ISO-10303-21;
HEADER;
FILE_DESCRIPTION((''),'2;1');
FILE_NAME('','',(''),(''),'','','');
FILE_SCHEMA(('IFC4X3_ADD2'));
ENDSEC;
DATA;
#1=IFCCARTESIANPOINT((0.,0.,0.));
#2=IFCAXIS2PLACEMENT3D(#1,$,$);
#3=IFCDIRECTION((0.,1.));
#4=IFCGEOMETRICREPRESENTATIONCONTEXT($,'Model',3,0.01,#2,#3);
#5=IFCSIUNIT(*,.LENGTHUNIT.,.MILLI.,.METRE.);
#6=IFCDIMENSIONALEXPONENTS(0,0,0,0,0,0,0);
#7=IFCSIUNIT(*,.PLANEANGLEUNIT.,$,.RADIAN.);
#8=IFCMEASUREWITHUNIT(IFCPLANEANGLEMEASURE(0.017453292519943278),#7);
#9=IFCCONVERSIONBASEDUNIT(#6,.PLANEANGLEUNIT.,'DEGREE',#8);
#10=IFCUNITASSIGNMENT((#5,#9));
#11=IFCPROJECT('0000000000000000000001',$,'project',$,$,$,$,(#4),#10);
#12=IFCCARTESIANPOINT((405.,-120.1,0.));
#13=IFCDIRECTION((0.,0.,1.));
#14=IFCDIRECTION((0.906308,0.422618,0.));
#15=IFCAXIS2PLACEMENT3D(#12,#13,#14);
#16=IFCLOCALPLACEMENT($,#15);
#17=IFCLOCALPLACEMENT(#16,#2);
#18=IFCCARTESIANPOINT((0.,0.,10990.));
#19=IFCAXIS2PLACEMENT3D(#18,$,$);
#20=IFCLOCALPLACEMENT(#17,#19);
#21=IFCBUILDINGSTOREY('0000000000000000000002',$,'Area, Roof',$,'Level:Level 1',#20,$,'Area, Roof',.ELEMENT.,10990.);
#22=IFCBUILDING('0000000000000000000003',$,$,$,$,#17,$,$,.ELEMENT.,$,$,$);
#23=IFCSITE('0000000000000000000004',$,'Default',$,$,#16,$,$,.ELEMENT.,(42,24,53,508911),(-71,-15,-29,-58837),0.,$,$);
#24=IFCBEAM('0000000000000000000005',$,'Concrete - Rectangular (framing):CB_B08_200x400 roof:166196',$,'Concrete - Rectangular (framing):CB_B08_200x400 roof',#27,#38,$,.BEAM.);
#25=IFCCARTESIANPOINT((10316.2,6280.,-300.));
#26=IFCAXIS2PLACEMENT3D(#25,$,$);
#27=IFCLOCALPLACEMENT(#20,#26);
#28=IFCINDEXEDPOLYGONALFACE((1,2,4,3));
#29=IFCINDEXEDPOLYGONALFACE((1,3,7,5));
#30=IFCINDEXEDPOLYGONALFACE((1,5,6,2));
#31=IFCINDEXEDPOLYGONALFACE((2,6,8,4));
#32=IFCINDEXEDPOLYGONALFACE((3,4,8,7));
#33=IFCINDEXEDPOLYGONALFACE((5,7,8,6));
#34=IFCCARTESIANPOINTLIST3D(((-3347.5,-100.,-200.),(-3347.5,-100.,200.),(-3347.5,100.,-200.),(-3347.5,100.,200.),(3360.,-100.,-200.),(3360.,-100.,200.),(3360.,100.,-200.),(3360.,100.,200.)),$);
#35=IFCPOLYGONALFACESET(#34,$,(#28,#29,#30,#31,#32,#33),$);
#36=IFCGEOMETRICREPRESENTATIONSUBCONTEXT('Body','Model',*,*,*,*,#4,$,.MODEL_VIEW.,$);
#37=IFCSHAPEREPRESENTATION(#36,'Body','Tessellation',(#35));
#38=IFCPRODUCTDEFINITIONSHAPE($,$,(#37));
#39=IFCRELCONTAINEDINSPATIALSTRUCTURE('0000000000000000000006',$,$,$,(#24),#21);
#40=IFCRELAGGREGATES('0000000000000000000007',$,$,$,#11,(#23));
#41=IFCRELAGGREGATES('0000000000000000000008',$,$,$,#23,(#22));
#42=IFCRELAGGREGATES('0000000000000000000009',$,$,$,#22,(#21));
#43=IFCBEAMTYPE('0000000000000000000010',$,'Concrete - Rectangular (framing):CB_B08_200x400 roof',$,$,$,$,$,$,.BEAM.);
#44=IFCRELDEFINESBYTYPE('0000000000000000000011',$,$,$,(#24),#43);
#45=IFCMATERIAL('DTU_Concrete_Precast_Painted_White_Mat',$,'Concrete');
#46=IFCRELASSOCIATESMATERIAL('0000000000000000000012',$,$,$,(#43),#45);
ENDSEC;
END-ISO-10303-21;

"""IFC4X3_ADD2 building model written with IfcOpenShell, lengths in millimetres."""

from ifc_helpers import new_model, entity, si_unit, converted_unit, direction, frame, origin, origin_2d_with_axis, place, context, subcontext, project, spatial, rectangle, extrude, source, transform, mapped, material, material_profile, profile_set, type_object, type_shapes, element, save


model = new_model("IFC4X3_ADD2")

# Units and contexts
model_context = context("Model", 3, precision=0.01, world=origin(), true_north=direction((0.0, 1.0)))
body_context = subcontext(model_context, "Body", "Model", "MODEL_VIEW")
ifc_project = project(units=[si_unit("LENGTHUNIT", "METRE", prefix="MILLI"), converted_unit("PLANEANGLEUNIT", "DEGREE", entity("IfcPlaneAngleMeasure", 0.017453292519943278), si_unit("PLANEANGLEUNIT", "RADIAN"), dimensions=[0, 0, 0, 0, 0, 0, 0])], contexts=[model_context])

# Site, building, storey
site_placement = place(None, frame((405.0, -120.1, 0.0), z_axis=(0.0, 0.0, 1.0), x_axis=(0.906308, 0.422618, 0.0)))
site = spatial("IfcSite", under=ifc_project, at=site_placement, Name="Default", CompositionType="ELEMENT", RefLatitude=(42, 24, 53, 508911), RefLongitude=(-71, -15, -29, -58837), RefElevation=0.0)
building_placement = place(site_placement, origin())
building = spatial("IfcBuilding", under=site, at=building_placement, CompositionType="ELEMENT")
storey_placement = place(building_placement, frame((0.0, 0.0, 10990.0)))
storey = spatial("IfcBuildingStorey", under=building, at=storey_placement, Name="Area, Roof", ObjectType="Level:Level 1", LongName="Area, Roof", CompositionType="ELEMENT", Elevation=10990.0)

# Beam
ifc_material_1 = material(Name="DTU_Concrete_Precast_Painted_White_Mat", Category="Concrete")
ifc_material_profile_1 = material_profile(ifc_material_1, rectangle(XDim=7137.5, YDim=200.0, at=origin_2d_with_axis()), Name="CB_B08_200x400 roof")
ifc_profile_set_1 = profile_set([ifc_material_profile_1], Name="CB_B08_200x400 roof")
beam_type_1 = type_object("IfcBeamType", Name="Concrete - Rectangular (framing):CB_B08_200x400 roof", PredefinedType="BEAM", material=ifc_profile_set_1)
shared_shape_1 = source(origin(), body_context, "Body", "SweptSolid", [
    extrude(rectangle(XDim=6707.5, YDim=200.0, at=origin_2d_with_axis()), frame((6.3, 0.0, -200.0), z_axis=(0.0, 0.0, 1.0), x_axis=(-1.0, 0.0, 0.0)), (0.0, 0.0, 1.0), 400.0),
])
type_shapes(beam_type_1, [shared_shape_1])
beam_placement = place(storey_placement, frame((10316.2, 6280.0, -300.0)))
element("IfcBeam", 1, at=beam_placement, inside=storey, type_object=beam_type_1, Name="Concrete - Rectangular (framing):CB_B08_200x400 roof:166196", ObjectType="Concrete - Rectangular (framing):CB_B08_200x400 roof", PredefinedType="BEAM", context=body_context, shape_type="MappedRepresentation", body=[
    mapped(shared_shape_1, transform((0.0, 0.0, 0.0), scale=1.0)),
])

save(model, "model.ifc")
